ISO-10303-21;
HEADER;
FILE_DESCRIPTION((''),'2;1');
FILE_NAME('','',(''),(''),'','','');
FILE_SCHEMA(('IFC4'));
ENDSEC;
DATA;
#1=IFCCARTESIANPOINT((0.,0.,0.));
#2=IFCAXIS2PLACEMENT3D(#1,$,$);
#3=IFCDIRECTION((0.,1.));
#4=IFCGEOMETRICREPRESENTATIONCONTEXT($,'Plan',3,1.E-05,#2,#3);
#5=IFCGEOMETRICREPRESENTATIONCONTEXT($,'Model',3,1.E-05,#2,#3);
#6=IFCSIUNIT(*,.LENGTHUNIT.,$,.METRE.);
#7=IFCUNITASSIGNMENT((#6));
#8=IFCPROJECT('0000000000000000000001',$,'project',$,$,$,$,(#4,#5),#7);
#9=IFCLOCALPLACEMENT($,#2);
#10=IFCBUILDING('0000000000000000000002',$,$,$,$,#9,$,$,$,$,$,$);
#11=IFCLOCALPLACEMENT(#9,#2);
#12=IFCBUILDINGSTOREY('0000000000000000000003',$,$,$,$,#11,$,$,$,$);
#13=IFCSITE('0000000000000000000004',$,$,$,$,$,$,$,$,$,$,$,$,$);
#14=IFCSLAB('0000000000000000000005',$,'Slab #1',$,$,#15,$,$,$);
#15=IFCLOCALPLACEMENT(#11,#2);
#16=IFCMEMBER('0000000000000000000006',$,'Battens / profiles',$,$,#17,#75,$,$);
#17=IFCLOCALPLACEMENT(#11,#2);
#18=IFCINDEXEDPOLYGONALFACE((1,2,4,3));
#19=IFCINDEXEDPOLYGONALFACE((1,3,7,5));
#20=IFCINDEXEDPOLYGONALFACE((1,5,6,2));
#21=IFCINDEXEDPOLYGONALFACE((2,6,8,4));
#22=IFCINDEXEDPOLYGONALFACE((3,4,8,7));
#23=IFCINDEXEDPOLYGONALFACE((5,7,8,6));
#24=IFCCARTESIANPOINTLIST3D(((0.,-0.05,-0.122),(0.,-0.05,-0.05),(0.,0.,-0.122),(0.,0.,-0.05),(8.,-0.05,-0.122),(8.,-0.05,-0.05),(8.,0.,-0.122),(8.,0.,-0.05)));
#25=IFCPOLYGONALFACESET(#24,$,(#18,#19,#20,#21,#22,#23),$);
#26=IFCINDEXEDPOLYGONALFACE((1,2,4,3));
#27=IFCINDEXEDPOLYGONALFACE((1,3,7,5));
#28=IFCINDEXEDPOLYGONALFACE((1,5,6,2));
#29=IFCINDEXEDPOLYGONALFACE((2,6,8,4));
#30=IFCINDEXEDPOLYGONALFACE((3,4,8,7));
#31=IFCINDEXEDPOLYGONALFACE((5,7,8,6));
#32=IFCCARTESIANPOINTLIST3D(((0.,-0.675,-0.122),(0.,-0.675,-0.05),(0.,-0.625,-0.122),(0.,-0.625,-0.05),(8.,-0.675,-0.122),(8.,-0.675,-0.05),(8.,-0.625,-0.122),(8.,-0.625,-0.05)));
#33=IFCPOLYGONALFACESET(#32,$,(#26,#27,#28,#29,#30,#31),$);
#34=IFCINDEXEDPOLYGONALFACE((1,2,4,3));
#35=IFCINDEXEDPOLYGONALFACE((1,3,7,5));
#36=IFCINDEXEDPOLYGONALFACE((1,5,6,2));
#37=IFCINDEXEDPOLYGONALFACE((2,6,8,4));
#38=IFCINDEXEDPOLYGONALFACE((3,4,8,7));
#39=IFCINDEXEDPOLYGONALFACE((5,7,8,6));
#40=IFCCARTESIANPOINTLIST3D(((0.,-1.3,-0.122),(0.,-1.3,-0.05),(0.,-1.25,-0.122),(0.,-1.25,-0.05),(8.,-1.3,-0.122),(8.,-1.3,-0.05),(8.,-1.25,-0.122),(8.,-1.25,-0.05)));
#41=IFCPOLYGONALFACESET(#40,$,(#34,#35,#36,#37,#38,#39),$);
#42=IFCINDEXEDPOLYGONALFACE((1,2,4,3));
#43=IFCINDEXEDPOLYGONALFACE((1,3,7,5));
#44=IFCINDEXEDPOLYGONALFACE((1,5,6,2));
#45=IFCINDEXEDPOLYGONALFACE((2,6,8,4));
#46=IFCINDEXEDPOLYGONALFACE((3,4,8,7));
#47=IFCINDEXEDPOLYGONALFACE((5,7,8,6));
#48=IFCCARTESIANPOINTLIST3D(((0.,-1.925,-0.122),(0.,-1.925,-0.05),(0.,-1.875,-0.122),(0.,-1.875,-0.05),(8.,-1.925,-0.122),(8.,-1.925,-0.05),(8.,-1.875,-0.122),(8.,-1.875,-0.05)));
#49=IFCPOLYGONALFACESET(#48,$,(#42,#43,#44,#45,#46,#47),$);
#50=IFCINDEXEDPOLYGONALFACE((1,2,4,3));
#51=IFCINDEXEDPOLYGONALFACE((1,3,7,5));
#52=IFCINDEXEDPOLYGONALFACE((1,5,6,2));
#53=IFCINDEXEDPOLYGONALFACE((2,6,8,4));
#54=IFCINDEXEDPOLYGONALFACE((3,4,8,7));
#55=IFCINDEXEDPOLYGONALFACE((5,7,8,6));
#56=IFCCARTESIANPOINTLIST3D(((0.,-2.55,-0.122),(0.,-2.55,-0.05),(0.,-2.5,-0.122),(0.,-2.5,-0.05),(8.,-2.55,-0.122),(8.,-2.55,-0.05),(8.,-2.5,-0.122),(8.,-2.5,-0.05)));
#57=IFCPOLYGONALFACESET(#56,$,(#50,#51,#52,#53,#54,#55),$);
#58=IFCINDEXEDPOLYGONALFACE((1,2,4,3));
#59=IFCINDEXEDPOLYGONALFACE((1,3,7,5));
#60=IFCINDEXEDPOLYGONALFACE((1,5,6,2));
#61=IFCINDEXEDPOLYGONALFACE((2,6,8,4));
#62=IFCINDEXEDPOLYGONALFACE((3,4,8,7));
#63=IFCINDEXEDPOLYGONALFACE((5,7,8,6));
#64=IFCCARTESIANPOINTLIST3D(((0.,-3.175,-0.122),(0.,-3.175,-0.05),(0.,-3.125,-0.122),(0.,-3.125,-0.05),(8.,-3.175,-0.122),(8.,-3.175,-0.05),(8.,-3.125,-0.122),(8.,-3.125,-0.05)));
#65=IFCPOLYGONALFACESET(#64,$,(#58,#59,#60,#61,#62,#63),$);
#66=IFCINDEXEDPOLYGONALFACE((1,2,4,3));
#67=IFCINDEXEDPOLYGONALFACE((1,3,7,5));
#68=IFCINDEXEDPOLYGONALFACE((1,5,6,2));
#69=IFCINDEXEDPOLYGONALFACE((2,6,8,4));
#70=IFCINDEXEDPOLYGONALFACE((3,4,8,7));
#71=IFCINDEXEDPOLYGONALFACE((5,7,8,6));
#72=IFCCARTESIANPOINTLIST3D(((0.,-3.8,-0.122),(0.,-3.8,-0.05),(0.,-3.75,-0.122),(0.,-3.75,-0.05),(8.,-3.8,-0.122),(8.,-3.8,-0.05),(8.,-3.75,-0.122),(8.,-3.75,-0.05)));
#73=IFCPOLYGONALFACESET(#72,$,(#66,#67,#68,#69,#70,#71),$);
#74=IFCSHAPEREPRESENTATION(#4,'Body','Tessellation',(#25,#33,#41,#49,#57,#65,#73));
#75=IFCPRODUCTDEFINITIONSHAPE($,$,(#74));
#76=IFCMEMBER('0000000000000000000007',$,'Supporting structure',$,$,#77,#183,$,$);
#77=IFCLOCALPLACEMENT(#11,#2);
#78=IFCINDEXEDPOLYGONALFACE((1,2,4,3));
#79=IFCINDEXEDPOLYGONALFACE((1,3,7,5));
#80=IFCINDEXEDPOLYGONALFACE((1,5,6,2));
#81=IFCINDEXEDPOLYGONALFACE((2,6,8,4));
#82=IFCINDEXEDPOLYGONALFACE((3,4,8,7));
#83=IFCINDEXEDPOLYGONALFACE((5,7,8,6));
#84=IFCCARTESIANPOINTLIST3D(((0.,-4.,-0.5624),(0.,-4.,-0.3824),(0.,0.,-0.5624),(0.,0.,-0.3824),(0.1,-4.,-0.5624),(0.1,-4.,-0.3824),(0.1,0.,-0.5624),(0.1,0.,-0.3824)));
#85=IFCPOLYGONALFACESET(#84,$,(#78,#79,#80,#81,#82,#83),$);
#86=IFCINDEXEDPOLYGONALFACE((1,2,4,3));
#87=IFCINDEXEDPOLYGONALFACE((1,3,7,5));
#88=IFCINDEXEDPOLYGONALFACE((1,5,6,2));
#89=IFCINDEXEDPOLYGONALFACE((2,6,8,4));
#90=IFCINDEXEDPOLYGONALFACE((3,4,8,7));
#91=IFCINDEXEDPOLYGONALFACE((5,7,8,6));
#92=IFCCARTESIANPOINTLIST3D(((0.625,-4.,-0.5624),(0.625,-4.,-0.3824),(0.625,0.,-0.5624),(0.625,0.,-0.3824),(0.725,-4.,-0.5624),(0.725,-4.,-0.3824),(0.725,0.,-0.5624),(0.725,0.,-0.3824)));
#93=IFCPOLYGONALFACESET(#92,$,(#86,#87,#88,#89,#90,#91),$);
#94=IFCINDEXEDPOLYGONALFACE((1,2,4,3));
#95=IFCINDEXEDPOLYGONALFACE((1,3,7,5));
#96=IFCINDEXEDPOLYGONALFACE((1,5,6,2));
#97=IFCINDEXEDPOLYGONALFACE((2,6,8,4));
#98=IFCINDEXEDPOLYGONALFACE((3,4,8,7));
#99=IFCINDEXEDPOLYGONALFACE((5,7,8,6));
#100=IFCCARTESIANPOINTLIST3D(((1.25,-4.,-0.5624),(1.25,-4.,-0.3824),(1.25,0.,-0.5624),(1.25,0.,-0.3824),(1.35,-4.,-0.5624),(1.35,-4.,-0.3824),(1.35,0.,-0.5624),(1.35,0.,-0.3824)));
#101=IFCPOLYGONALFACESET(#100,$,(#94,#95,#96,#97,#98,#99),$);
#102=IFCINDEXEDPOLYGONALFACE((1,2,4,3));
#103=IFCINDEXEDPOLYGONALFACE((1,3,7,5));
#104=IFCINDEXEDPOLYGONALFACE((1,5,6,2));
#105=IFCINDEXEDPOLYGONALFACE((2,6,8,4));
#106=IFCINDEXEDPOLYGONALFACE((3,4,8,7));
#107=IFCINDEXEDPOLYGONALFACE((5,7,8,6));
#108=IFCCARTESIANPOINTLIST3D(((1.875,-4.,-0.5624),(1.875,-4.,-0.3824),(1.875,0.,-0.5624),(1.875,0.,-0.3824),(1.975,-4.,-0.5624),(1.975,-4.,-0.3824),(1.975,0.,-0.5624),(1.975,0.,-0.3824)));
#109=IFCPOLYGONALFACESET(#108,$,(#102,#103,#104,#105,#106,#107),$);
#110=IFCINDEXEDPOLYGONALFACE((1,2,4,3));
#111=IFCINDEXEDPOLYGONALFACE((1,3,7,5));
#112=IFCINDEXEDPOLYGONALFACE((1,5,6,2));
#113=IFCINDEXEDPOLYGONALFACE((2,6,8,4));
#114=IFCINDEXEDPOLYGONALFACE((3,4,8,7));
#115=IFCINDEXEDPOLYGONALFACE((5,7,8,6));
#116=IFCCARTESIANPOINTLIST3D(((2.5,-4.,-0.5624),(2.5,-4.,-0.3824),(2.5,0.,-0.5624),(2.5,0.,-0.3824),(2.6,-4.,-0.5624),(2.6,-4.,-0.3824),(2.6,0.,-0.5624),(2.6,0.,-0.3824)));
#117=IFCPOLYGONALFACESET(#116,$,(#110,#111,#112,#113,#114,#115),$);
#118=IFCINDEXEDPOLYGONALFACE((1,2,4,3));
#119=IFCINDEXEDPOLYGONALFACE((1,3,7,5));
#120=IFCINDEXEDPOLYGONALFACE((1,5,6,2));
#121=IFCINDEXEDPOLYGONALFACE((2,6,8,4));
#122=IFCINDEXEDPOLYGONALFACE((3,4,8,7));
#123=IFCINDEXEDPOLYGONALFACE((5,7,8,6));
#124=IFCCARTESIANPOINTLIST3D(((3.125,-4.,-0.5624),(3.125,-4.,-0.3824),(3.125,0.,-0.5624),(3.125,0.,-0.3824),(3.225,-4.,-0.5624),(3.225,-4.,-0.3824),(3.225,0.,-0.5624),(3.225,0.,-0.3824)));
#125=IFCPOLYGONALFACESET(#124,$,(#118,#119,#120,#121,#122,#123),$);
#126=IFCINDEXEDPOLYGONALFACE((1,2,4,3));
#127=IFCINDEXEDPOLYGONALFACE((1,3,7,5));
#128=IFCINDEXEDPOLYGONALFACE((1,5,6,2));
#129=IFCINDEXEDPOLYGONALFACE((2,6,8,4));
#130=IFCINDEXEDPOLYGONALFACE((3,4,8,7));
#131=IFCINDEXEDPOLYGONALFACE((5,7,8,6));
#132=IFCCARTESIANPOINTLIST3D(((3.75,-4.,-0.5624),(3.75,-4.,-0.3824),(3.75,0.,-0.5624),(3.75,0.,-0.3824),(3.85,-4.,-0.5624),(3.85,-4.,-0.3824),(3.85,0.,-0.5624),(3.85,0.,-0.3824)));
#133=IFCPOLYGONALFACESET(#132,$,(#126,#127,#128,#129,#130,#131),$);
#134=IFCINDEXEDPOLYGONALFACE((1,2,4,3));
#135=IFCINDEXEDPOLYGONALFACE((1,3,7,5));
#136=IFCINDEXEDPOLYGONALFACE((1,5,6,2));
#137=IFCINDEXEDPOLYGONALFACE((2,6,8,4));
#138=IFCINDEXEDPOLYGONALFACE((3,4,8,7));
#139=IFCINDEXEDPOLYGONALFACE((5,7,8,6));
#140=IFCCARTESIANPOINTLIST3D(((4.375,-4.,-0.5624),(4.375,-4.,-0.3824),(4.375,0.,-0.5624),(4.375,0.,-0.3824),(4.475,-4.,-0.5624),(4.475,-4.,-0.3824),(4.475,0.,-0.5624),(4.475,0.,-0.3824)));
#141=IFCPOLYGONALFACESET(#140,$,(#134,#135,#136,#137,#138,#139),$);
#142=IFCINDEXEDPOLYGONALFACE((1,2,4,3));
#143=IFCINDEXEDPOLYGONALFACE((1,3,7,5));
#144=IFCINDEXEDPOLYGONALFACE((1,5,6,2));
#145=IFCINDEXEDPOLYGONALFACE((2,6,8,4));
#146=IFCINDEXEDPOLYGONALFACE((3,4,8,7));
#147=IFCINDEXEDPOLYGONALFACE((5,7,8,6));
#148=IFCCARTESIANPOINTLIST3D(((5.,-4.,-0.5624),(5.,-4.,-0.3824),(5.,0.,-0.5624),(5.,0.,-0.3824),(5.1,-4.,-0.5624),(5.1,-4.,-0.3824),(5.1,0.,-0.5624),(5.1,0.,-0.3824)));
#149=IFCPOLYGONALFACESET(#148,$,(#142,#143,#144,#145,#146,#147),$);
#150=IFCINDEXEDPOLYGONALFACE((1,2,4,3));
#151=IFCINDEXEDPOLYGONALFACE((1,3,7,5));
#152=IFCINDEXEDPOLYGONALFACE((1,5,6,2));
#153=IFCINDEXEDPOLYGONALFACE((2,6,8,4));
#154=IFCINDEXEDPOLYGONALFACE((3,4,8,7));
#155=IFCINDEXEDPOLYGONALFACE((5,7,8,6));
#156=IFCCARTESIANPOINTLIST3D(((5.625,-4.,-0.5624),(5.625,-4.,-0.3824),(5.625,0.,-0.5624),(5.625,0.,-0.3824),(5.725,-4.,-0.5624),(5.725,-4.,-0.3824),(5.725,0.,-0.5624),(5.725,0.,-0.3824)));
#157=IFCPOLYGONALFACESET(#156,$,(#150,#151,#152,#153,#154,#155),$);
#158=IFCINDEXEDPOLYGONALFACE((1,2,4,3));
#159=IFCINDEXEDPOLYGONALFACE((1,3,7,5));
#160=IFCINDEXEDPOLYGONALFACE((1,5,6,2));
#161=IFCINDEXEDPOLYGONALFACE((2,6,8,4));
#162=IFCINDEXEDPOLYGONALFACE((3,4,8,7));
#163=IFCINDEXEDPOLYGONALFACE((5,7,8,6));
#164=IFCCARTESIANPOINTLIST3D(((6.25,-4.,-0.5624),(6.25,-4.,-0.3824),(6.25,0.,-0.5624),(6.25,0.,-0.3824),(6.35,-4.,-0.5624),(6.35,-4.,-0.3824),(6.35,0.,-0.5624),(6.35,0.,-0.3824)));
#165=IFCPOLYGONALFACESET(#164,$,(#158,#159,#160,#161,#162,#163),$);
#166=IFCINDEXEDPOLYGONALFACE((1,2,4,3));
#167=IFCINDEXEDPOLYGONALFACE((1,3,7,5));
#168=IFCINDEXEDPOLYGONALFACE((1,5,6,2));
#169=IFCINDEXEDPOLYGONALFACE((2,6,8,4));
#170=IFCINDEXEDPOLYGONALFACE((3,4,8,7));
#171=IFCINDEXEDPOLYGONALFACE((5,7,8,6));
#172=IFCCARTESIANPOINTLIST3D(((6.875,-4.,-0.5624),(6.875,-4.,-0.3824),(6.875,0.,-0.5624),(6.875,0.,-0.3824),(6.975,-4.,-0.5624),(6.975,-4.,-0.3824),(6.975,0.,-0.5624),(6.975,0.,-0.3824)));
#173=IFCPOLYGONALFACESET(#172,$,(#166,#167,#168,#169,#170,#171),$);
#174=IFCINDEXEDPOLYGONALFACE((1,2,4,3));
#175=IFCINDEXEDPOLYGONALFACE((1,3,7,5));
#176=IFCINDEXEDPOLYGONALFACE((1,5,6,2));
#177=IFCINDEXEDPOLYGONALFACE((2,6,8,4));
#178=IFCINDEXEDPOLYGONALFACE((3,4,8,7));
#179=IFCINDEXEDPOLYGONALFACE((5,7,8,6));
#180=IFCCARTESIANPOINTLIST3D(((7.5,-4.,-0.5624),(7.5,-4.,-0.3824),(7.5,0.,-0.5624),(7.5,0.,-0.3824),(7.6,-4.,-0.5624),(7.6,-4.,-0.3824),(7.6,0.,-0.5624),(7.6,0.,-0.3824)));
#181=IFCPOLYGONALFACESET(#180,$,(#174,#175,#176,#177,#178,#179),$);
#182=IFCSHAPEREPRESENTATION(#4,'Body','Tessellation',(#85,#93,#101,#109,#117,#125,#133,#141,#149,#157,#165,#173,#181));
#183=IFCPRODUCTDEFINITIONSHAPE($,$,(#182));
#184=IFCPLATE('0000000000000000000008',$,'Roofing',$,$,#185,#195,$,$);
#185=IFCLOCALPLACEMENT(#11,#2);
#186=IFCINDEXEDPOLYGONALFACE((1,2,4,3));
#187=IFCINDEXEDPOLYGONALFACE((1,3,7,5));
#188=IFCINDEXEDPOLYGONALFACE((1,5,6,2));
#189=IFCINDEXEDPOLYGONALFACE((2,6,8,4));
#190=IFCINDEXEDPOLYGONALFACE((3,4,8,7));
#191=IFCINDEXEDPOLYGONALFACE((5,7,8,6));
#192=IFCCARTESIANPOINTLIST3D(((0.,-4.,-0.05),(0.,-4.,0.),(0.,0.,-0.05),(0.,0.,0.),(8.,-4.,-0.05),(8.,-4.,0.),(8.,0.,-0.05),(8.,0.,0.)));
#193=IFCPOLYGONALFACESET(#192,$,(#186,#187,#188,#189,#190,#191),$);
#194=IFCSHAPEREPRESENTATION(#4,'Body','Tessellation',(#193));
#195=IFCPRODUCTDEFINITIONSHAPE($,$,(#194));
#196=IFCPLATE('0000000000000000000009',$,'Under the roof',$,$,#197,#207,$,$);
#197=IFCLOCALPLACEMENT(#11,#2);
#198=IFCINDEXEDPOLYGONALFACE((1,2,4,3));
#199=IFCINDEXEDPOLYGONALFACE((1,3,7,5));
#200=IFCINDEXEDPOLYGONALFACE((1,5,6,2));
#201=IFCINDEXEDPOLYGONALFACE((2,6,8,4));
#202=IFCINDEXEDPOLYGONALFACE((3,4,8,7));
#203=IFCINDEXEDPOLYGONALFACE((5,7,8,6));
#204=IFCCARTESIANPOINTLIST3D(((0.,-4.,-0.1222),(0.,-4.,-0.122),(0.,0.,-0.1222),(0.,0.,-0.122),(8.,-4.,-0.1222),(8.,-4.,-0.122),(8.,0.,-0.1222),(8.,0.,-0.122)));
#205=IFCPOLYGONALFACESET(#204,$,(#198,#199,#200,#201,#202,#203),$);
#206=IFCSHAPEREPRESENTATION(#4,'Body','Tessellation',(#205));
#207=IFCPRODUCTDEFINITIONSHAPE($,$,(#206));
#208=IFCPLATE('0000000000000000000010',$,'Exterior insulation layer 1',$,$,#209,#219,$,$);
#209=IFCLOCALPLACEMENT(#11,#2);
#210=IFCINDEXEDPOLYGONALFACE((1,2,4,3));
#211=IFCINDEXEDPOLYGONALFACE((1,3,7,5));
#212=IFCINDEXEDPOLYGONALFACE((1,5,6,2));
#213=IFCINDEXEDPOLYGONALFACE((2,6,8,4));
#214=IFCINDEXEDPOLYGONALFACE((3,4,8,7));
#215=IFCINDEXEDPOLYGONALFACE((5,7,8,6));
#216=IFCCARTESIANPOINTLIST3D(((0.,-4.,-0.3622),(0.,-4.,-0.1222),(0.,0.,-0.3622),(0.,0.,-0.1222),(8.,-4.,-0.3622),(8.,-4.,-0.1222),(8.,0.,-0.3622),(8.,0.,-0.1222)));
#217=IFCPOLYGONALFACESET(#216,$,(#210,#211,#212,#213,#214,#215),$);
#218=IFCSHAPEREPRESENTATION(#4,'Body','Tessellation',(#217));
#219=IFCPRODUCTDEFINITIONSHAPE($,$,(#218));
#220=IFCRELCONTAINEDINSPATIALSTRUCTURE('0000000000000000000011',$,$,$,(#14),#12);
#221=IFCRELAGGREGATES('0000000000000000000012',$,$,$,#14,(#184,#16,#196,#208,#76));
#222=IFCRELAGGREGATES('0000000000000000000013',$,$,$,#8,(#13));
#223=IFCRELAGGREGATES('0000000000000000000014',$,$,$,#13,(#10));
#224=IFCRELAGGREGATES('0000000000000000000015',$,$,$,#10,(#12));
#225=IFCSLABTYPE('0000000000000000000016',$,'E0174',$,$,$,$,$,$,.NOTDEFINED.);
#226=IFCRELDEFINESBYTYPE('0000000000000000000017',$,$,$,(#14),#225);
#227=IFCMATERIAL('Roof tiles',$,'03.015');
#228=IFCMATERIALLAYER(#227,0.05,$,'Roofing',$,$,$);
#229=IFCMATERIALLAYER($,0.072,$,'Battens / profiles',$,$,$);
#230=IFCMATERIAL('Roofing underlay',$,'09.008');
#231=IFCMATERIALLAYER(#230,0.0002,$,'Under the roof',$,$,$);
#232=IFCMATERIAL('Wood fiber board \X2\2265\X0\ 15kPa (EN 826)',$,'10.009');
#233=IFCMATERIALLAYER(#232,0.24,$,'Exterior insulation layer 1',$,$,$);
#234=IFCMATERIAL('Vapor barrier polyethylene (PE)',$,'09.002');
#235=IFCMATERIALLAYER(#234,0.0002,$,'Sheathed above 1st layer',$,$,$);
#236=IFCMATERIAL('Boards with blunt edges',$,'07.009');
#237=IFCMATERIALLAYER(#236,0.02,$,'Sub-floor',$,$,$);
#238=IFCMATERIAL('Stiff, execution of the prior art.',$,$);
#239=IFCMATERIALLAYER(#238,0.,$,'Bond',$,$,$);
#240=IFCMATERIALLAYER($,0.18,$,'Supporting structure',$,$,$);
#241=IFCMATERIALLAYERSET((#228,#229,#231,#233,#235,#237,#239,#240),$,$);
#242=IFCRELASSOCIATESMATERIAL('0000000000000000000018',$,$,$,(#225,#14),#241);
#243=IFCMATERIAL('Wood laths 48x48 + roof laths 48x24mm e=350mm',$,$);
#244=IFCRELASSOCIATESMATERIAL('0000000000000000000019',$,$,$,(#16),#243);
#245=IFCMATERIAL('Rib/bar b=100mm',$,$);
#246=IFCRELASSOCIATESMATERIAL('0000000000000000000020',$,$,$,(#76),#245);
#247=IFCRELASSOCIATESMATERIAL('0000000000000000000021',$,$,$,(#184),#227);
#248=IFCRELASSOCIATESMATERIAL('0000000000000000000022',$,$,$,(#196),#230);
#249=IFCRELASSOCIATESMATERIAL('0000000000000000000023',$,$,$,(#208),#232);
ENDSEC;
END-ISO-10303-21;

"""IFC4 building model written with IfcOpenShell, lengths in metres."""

from ifc_helpers import new_model, si_unit, direction, frame, frame_2d, origin, origin_with_axes, place, context, project, spatial, rectangle, extrude, material, layer, layer_set, type_object, element, aggregate, save


model = new_model("IFC4")

# Units and contexts
plan_context = context("Plan", 3, precision=1e-05, world=origin(), true_north=direction((0.0, 1.0)))
model_context = context("Model", 3, precision=1e-05, world=origin(), true_north=direction((0.0, 1.0)))
ifc_project = project(units=[si_unit("LENGTHUNIT", "METRE")], contexts=[plan_context, model_context])

# Site, building, storey
site = spatial("IfcSite", under=ifc_project)
building_placement = place(None, origin())
building = spatial("IfcBuilding", under=site, at=building_placement)
storey_placement = place(building_placement, origin())
storey = spatial("IfcBuildingStorey", under=building, at=storey_placement)

# Slab, members, plates
ifc_material_1 = material(Name="Roof tiles", Category="03.015")
ifc_layer_1 = layer(ifc_material_1, 0.05, Name="Roofing")
ifc_layer_2 = layer(None, 0.072, Name="Battens / profiles")
ifc_material_2 = material(Name="Roofing underlay", Category="09.008")
ifc_layer_3 = layer(ifc_material_2, 0.0002, Name="Under the roof")
ifc_material_3 = material(Name="Wood fiber board ≥ 15kPa (EN 826)", Category="10.009")
ifc_layer_4 = layer(ifc_material_3, 0.24, Name="Exterior insulation layer 1")
ifc_material_4 = material(Name="Vapor barrier polyethylene (PE)", Category="09.002")
ifc_layer_5 = layer(ifc_material_4, 0.0002, Name="Sheathed above 1st layer")
ifc_material_5 = material(Name="Boards with blunt edges", Category="07.009")
ifc_layer_6 = layer(ifc_material_5, 0.02, Name="Sub-floor")
ifc_material_6 = material(Name="Stiff, execution of the prior art.")
ifc_layer_7 = layer(ifc_material_6, 0.0, Name="Bond")
ifc_layer_8 = layer(None, 0.18, Name="Supporting structure")
ifc_layer_set = layer_set([ifc_layer_1, ifc_layer_2, ifc_layer_3, ifc_layer_4, ifc_layer_5, ifc_layer_6, ifc_layer_7, ifc_layer_8])
slab_type = type_object("IfcSlabType", Name="E0174", PredefinedType="NOTDEFINED", material=ifc_layer_set)
slab_placement = place(None, frame((0.0, 0.0, 0.0), z_axis=(0.0, 0.0, -1.0), x_axis=(1.0, 0.0, 0.0)))
slab = element("IfcSlab", 1, at=slab_placement, inside=storey, type_object=slab_type, material=ifc_layer_set, Name="Slab #1")
ifc_material_7 = material(Name="Wood laths 48x48 + roof laths 48x24mm e=350mm")
member_1_placement = place(slab_placement, origin())
member_1 = element("IfcMember", 2, at=member_1_placement, material=ifc_material_7, Name="Battens / profiles", context=plan_context, shape_type="SweptSolid", body=[
    extrude(rectangle(XDim=0.05, YDim=0.072, at=frame_2d((0.025, 0.036), x_axis=(1.0, 0.0))), frame((0.0, 0.0, 0.05), z_axis=(1.0, 0.0, 0.0), x_axis=(0.0, 1.0, 0.0)), (0.0, 0.0, 1.0), 8.0),
    extrude(rectangle(XDim=0.05, YDim=0.072, at=frame_2d((0.025, 0.036), x_axis=(1.0, 0.0))), frame((0.0, 0.625, 0.05), z_axis=(1.0, 0.0, 0.0), x_axis=(0.0, 1.0, 0.0)), (0.0, 0.0, 1.0), 8.0),
    extrude(rectangle(XDim=0.05, YDim=0.072, at=frame_2d((0.025, 0.036), x_axis=(1.0, 0.0))), frame((0.0, 1.25, 0.05), z_axis=(1.0, 0.0, 0.0), x_axis=(0.0, 1.0, 0.0)), (0.0, 0.0, 1.0), 8.0),
    extrude(rectangle(XDim=0.05, YDim=0.072, at=frame_2d((0.025, 0.036), x_axis=(1.0, 0.0))), frame((0.0, 1.875, 0.05), z_axis=(1.0, 0.0, 0.0), x_axis=(0.0, 1.0, 0.0)), (0.0, 0.0, 1.0), 8.0),
    extrude(rectangle(XDim=0.05, YDim=0.072, at=frame_2d((0.025, 0.036), x_axis=(1.0, 0.0))), frame((0.0, 2.5, 0.05), z_axis=(1.0, 0.0, 0.0), x_axis=(0.0, 1.0, 0.0)), (0.0, 0.0, 1.0), 8.0),
    extrude(rectangle(XDim=0.05, YDim=0.072, at=frame_2d((0.025, 0.036), x_axis=(1.0, 0.0))), frame((0.0, 3.125, 0.05), z_axis=(1.0, 0.0, 0.0), x_axis=(0.0, 1.0, 0.0)), (0.0, 0.0, 1.0), 8.0),
    extrude(rectangle(XDim=0.05, YDim=0.072, at=frame_2d((0.025, 0.036), x_axis=(1.0, 0.0))), frame((0.0, 3.75, 0.05), z_axis=(1.0, 0.0, 0.0), x_axis=(0.0, 1.0, 0.0)), (0.0, 0.0, 1.0), 8.0),
])
ifc_material_8 = material(Name="Rib/bar b=100mm")
member_2_placement = place(slab_placement, origin())
member_2 = element("IfcMember", 3, at=member_2_placement, material=ifc_material_8, Name="Supporting structure", context=plan_context, shape_type="SweptSolid", body=[
    extrude(rectangle(XDim=0.1, YDim=0.18, at=frame_2d((0.05, 0.09), x_axis=(1.0, 0.0))), frame((0.0, 4.0, 0.3824), z_axis=(0.0, -1.0, 0.0), x_axis=(1.0, 0.0, 0.0)), (0.0, 0.0, 1.0), 4.0),
    extrude(rectangle(XDim=0.1, YDim=0.18, at=frame_2d((0.05, 0.09), x_axis=(1.0, 0.0))), frame((0.625, 4.0, 0.3824), z_axis=(0.0, -1.0, 0.0), x_axis=(1.0, 0.0, 0.0)), (0.0, 0.0, 1.0), 4.0),
    extrude(rectangle(XDim=0.1, YDim=0.18, at=frame_2d((0.05, 0.09), x_axis=(1.0, 0.0))), frame((1.25, 4.0, 0.3824), z_axis=(0.0, -1.0, 0.0), x_axis=(1.0, 0.0, 0.0)), (0.0, 0.0, 1.0), 4.0),
    extrude(rectangle(XDim=0.1, YDim=0.18, at=frame_2d((0.05, 0.09), x_axis=(1.0, 0.0))), frame((1.875, 4.0, 0.3824), z_axis=(0.0, -1.0, 0.0), x_axis=(1.0, 0.0, 0.0)), (0.0, 0.0, 1.0), 4.0),
    extrude(rectangle(XDim=0.1, YDim=0.18, at=frame_2d((0.05, 0.09), x_axis=(1.0, 0.0))), frame((2.5, 4.0, 0.3824), z_axis=(0.0, -1.0, 0.0), x_axis=(1.0, 0.0, 0.0)), (0.0, 0.0, 1.0), 4.0),
    extrude(rectangle(XDim=0.1, YDim=0.18, at=frame_2d((0.05, 0.09), x_axis=(1.0, 0.0))), frame((3.125, 4.0, 0.3824), z_axis=(0.0, -1.0, 0.0), x_axis=(1.0, 0.0, 0.0)), (0.0, 0.0, 1.0), 4.0),
    extrude(rectangle(XDim=0.1, YDim=0.18, at=frame_2d((0.05, 0.09), x_axis=(1.0, 0.0))), frame((3.75, 4.0, 0.3824), z_axis=(0.0, -1.0, 0.0), x_axis=(1.0, 0.0, 0.0)), (0.0, 0.0, 1.0), 4.0),
    extrude(rectangle(XDim=0.1, YDim=0.18, at=frame_2d((0.05, 0.09), x_axis=(1.0, 0.0))), frame((4.375, 4.0, 0.3824), z_axis=(0.0, -1.0, 0.0), x_axis=(1.0, 0.0, 0.0)), (0.0, 0.0, 1.0), 4.0),
    extrude(rectangle(XDim=0.1, YDim=0.18, at=frame_2d((0.05, 0.09), x_axis=(1.0, 0.0))), frame((5.0, 4.0, 0.3824), z_axis=(0.0, -1.0, 0.0), x_axis=(1.0, 0.0, 0.0)), (0.0, 0.0, 1.0), 4.0),
    extrude(rectangle(XDim=0.1, YDim=0.18, at=frame_2d((0.05, 0.09), x_axis=(1.0, 0.0))), frame((5.625, 4.0, 0.3824), z_axis=(0.0, -1.0, 0.0), x_axis=(1.0, 0.0, 0.0)), (0.0, 0.0, 1.0), 4.0),
    extrude(rectangle(XDim=0.1, YDim=0.18, at=frame_2d((0.05, 0.09), x_axis=(1.0, 0.0))), frame((6.25, 4.0, 0.3824), z_axis=(0.0, -1.0, 0.0), x_axis=(1.0, 0.0, 0.0)), (0.0, 0.0, 1.0), 4.0),
    extrude(rectangle(XDim=0.1, YDim=0.18, at=frame_2d((0.05, 0.09), x_axis=(1.0, 0.0))), frame((6.875, 4.0, 0.3824), z_axis=(0.0, -1.0, 0.0), x_axis=(1.0, 0.0, 0.0)), (0.0, 0.0, 1.0), 4.0),
    extrude(rectangle(XDim=0.1, YDim=0.18, at=frame_2d((0.05, 0.09), x_axis=(1.0, 0.0))), frame((7.5, 4.0, 0.3824), z_axis=(0.0, -1.0, 0.0), x_axis=(1.0, 0.0, 0.0)), (0.0, 0.0, 1.0), 4.0),
])
plate_1_placement = place(slab_placement, origin())
plate_1 = element("IfcPlate", 4, at=plate_1_placement, material=ifc_material_1, Name="Roofing", context=plan_context, shape_type="SweptSolid", body=[
    extrude(rectangle(XDim=8.0, YDim=4.0, at=frame_2d((4.0, 2.0), x_axis=(1.0, 0.0))), origin_with_axes(), (0.0, 0.0, 1.0), 0.05),
])
plate_2_placement = place(slab_placement, origin())
plate_2 = element("IfcPlate", 5, at=plate_2_placement, material=ifc_material_2, Name="Under the roof", context=plan_context, shape_type="SweptSolid", body=[
    extrude(rectangle(XDim=8.0, YDim=4.0, at=frame_2d((4.0, 2.0), x_axis=(1.0, 0.0))), frame((0.0, 0.0, 0.122), z_axis=(0.0, 0.0, 1.0), x_axis=(1.0, 0.0, 0.0)), (0.0, 0.0, 1.0), 0.0002),
])
plate_3_placement = place(slab_placement, origin())
plate_3 = element("IfcPlate", 6, at=plate_3_placement, material=ifc_material_3, Name="Exterior insulation layer 1", context=plan_context, shape_type="SweptSolid", body=[
    extrude(rectangle(XDim=8.0, YDim=4.0, at=frame_2d((4.0, 2.0), x_axis=(1.0, 0.0))), frame((0.0, 0.0, 0.1222), z_axis=(0.0, 0.0, 1.0), x_axis=(1.0, 0.0, 0.0)), (0.0, 0.0, 1.0), 0.24),
])
aggregate(slab, [plate_1, member_1, plate_2, plate_3, member_2])

save(model, "model.ifc")
